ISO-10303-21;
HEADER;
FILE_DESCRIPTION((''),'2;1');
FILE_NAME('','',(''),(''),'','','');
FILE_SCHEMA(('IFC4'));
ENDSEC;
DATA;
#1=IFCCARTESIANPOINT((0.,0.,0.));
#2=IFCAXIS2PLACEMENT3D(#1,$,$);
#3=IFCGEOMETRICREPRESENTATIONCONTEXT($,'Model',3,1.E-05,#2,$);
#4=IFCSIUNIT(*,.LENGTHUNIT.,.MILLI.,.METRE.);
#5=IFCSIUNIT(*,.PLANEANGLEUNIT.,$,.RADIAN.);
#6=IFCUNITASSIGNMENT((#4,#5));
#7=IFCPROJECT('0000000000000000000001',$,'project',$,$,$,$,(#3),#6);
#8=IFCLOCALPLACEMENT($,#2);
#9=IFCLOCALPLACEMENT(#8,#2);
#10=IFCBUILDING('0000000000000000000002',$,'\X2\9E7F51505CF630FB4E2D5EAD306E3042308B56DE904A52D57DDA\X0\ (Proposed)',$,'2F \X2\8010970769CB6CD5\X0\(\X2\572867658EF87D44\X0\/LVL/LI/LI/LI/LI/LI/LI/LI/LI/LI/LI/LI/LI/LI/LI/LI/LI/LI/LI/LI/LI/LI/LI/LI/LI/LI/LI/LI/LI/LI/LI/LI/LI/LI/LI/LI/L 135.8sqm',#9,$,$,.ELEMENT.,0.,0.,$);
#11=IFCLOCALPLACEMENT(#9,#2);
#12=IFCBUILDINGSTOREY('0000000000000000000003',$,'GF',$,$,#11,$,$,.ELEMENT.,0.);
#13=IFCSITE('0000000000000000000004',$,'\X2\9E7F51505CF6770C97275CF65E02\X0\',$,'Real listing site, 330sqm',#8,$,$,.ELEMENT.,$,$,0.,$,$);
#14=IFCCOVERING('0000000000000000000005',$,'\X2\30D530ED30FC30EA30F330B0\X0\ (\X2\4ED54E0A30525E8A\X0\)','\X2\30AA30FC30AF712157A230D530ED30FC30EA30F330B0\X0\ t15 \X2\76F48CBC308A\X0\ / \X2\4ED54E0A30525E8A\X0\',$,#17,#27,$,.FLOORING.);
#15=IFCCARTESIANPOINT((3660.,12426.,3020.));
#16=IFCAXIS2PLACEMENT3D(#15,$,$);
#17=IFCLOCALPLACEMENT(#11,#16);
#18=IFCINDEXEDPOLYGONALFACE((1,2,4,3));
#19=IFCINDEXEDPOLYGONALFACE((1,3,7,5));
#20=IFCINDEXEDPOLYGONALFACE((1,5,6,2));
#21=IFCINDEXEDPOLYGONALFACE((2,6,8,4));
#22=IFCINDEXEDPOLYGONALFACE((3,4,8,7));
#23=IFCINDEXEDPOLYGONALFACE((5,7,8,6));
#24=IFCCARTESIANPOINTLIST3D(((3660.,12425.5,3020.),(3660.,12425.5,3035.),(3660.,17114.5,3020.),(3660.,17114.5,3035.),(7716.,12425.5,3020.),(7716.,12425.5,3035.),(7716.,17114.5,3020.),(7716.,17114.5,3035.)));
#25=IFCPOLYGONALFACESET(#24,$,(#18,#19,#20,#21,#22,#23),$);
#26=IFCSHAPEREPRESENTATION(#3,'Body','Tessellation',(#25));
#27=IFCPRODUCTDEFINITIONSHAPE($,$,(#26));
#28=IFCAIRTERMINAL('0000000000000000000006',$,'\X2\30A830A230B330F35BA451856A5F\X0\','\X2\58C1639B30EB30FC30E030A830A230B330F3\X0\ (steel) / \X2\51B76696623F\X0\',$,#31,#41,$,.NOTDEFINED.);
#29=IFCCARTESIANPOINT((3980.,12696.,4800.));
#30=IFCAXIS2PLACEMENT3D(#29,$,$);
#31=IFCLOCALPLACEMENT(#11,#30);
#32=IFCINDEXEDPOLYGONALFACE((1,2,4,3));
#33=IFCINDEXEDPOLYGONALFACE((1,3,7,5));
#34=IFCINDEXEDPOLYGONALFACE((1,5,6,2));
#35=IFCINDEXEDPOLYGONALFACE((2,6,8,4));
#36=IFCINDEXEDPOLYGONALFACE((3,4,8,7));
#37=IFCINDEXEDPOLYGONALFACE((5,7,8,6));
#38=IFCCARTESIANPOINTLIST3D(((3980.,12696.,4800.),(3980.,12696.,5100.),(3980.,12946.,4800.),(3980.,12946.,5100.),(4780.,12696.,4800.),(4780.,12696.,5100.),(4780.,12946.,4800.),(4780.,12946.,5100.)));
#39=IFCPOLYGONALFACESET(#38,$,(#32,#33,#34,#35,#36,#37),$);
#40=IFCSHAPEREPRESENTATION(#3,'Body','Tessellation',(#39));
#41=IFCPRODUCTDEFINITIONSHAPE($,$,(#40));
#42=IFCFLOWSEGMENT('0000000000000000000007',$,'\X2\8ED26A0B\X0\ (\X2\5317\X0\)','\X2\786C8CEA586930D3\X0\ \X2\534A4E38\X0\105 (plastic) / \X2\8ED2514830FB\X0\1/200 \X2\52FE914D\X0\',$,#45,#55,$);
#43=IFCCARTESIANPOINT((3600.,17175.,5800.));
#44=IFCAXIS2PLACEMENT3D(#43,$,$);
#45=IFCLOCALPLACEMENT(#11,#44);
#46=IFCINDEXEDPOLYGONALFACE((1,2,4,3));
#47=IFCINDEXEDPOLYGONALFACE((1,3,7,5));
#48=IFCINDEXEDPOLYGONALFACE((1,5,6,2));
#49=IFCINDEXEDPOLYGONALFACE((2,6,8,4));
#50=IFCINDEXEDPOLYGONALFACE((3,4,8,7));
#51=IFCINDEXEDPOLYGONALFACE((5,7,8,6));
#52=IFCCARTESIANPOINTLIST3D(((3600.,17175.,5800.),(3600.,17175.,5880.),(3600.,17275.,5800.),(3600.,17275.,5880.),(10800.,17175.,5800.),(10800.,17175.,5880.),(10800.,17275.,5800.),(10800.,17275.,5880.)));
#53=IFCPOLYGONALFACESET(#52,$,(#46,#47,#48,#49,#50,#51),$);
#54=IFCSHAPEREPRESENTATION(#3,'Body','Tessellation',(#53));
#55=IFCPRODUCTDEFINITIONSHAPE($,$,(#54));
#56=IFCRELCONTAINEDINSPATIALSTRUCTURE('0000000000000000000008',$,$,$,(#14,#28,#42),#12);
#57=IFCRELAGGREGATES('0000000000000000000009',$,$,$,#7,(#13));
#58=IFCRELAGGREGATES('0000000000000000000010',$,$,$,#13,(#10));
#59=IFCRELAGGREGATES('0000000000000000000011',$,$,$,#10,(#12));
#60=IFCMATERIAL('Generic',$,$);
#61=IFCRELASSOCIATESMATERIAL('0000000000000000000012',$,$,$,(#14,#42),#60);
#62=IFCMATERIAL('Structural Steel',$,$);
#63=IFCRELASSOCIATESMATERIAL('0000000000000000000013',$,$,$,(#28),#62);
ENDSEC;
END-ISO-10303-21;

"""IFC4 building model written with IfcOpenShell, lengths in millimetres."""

from ifc_helpers import new_model, si_unit, frame, frame_2d, origin, place, context, project, spatial, rectangle, extrude, material, element, save


model = new_model("IFC4")

# Units and contexts
model_context = context("Model", 3, precision=1e-05, world=origin())
ifc_project = project(units=[si_unit("LENGTHUNIT", "METRE", prefix="MILLI"), si_unit("PLANEANGLEUNIT", "RADIAN")], contexts=[model_context])

# Site, building, storey
site_placement = place(None, origin())
site = spatial("IfcSite", under=ifc_project, at=site_placement, Name="鹿児島県霧島市", ObjectType="Real listing site, 330sqm", CompositionType="ELEMENT", RefElevation=0.0)
building_placement = place(site_placement, origin())
building = spatial("IfcBuilding", under=site, at=building_placement, Name="鹿児島・中庭のある回遊動線 (Proposed)", ObjectType="2F 耐震構法(在来軸組/LVL/LI/LI/LI/LI/LI/LI/LI/LI/LI/LI/LI/LI/LI/LI/LI/LI/LI/LI/LI/LI/LI/LI/LI/LI/LI/LI/LI/LI/LI/LI/LI/LI/LI/LI/LI/L 135.8sqm", CompositionType="ELEMENT", ElevationOfRefHeight=0.0, ElevationOfTerrain=0.0)
storey_placement = place(building_placement, origin())
storey = spatial("IfcBuildingStorey", under=building, at=storey_placement, Name="GF", CompositionType="ELEMENT", Elevation=0.0)

# Shared definitions
ifc_material_1 = material(Name="Structural Steel")

# Covering
ifc_material_2 = material(Name="Generic")
covering_placement = place(storey_placement, frame((3660.0, 12426.0, 3020.0)))
element("IfcCovering", 1, at=covering_placement, inside=storey, material=ifc_material_2, Name="フローリング (仕上げ床)", Description="オーク無垢フローリング t15 直貼り / 仕上げ床", PredefinedType="FLOORING", context=model_context, shape_type="SweptSolid", body=[
    extrude(rectangle(XDim=4056.0, YDim=4689.0, at=frame_2d((2028.0, 2344.0))), frame((3660.0, 12426.0, 3020.0)), (0.0, 0.0, 1.0), 15.0),
])

# Air terminal
air_terminal_placement = place(storey_placement, frame((3980.0, 12696.0, 4800.0)))
element("IfcAirTerminal", 2, at=air_terminal_placement, inside=storey, material=ifc_material_1, Name="エアコン室内機", Description="壁掛ルームエアコン (steel) / 冷暖房", PredefinedType="NOTDEFINED", context=model_context, shape_type="SweptSolid", body=[
    extrude(rectangle(XDim=800.0, YDim=250.0, at=frame_2d((400.0, 125.0))), frame((3980.0, 12696.0, 4800.0)), (0.0, 0.0, 1.0), 300.0),
])

# Flow segment
flow_segment_placement = place(storey_placement, frame((3600.0, 17175.0, 5800.0)))
element("IfcFlowSegment", 3, at=flow_segment_placement, inside=storey, material=ifc_material_2, Name="軒樋 (北)", Description="硬質塩ビ 半丸105 (plastic) / 軒先・1/200 勾配", context=model_context, shape_type="SweptSolid", body=[
    extrude(rectangle(XDim=7200.0, YDim=100.0, at=frame_2d((3600.0, 50.0))), frame((3600.0, 17175.0, 5800.0)), (0.0, 0.0, 1.0), 80.0),
])

save(model, "model.ifc")
